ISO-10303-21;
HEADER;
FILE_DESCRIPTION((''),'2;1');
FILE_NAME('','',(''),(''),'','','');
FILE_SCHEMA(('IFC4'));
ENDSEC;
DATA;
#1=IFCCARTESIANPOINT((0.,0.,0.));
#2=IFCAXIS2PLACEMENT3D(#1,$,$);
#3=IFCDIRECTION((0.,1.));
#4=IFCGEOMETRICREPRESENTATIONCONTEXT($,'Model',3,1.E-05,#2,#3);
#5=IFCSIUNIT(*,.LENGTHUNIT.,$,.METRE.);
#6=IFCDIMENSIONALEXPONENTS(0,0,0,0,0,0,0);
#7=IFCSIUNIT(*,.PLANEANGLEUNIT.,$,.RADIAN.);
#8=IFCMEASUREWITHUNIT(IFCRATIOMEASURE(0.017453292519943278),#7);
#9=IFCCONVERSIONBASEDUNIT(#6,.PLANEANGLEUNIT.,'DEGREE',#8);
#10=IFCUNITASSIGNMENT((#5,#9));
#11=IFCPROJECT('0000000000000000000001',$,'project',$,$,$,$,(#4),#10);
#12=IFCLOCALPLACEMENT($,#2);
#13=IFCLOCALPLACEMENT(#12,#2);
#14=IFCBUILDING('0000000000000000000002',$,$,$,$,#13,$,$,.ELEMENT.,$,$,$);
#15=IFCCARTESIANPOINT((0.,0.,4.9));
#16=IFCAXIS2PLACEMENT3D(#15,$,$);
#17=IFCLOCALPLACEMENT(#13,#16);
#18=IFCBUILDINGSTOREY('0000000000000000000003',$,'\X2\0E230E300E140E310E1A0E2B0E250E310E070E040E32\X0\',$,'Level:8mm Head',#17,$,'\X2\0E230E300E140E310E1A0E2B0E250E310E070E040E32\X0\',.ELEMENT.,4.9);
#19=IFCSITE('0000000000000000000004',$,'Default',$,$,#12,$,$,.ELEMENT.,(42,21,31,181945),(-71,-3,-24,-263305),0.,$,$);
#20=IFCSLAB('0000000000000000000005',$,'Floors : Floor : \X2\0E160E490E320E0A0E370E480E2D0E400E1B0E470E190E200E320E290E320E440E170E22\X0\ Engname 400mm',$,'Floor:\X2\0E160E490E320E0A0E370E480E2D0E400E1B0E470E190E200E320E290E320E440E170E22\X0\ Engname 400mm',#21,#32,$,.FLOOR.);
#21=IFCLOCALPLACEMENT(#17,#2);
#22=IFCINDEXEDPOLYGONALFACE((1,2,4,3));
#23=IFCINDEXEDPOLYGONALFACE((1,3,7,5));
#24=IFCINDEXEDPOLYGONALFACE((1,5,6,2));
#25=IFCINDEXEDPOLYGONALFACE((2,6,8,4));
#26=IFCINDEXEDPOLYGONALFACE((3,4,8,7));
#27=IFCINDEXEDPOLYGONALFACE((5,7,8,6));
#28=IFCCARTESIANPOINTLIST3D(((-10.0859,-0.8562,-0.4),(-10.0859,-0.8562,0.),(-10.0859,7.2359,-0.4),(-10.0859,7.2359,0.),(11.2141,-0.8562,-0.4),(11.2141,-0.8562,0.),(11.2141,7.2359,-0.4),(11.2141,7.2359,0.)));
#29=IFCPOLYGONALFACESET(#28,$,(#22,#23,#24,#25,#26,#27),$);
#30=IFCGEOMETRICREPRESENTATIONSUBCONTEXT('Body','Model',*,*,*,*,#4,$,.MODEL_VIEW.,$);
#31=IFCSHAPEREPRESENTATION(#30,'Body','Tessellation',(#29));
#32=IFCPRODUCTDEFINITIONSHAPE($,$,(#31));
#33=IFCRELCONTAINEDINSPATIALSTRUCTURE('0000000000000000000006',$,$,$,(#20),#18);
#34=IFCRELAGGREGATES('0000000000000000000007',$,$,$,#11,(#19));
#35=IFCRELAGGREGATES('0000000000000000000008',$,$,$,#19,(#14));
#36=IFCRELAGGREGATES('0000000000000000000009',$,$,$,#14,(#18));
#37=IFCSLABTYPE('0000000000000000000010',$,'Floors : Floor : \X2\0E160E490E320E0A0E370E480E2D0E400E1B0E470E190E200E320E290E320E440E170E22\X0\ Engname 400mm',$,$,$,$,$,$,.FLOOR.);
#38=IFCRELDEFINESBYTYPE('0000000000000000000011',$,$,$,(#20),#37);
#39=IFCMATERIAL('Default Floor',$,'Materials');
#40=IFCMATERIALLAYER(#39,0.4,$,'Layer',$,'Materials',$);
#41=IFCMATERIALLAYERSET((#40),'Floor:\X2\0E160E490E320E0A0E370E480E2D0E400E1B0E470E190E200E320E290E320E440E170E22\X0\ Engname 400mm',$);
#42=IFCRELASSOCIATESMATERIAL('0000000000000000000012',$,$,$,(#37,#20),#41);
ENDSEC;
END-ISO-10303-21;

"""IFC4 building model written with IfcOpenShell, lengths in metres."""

from ifc_helpers import new_model, entity, si_unit, converted_unit, direction, frame, frame_2d, origin, place, context, subcontext, project, spatial, rectangle, extrude, material, layer, layer_set, layer_usage, type_object, element, save


model = new_model("IFC4")

# Units and contexts
model_context = context("Model", 3, precision=1e-05, world=origin(), true_north=direction((0.0, 1.0)))
body_context = subcontext(model_context, "Body", "Model", "MODEL_VIEW")
ifc_project = project(units=[si_unit("LENGTHUNIT", "METRE"), converted_unit("PLANEANGLEUNIT", "DEGREE", entity("IfcRatioMeasure", 0.017453292519943278), si_unit("PLANEANGLEUNIT", "RADIAN"), dimensions=[0, 0, 0, 0, 0, 0, 0])], contexts=[model_context])

# Site, building, storey
site_placement = place(None, origin())
site = spatial("IfcSite", under=ifc_project, at=site_placement, Name="Default", CompositionType="ELEMENT", RefLatitude=(42, 21, 31, 181945), RefLongitude=(-71, -3, -24, -263305), RefElevation=0.0)
building_placement = place(site_placement, origin())
building = spatial("IfcBuilding", under=site, at=building_placement, CompositionType="ELEMENT")
storey_placement = place(building_placement, frame((0.0, 0.0, 4.9)))
storey = spatial("IfcBuildingStorey", under=building, at=storey_placement, Name="ระดับหลังคา", ObjectType="Level:8mm Head", LongName="ระดับหลังคา", CompositionType="ELEMENT", Elevation=4.9)

# Slab
ifc_material = material(Name="Default Floor", Category="Materials")
ifc_layer = layer(ifc_material, 0.4, Name="Layer", Category="Materials")
ifc_layer_set = layer_set([ifc_layer], Name="Floor:ถ้าชื่อเป็นภาษาไทย Engname 400mm")
ifc_layer_usage = layer_usage(ifc_layer_set, "AXIS3", "POSITIVE", 0.0)
slab_type = type_object("IfcSlabType", Name="Floors : Floor : ถ้าชื่อเป็นภาษาไทย Engname 400mm", PredefinedType="FLOOR", material=ifc_layer_set)
slab_placement = place(storey_placement, origin())
element("IfcSlab", 1, at=slab_placement, inside=storey, type_object=slab_type, material=ifc_layer_usage, Name="Floors : Floor : ถ้าชื่อเป็นภาษาไทย Engname 400mm", ObjectType="Floor:ถ้าชื่อเป็นภาษาไทย Engname 400mm", PredefinedType="FLOOR", context=body_context, shape_type="SweptSolid", body=[
    extrude(rectangle(XDim=8.0921, YDim=21.3, at=frame_2d((0.0, 0.0), x_axis=(1.0, 0.0))), frame((0.5641, 3.1898, 0.0), z_axis=(0.0, 0.0, -1.0), x_axis=(0.0, 1.0, 0.0)), (0.0, 0.0, 1.0), 0.4),
])

save(model, "model.ifc")
